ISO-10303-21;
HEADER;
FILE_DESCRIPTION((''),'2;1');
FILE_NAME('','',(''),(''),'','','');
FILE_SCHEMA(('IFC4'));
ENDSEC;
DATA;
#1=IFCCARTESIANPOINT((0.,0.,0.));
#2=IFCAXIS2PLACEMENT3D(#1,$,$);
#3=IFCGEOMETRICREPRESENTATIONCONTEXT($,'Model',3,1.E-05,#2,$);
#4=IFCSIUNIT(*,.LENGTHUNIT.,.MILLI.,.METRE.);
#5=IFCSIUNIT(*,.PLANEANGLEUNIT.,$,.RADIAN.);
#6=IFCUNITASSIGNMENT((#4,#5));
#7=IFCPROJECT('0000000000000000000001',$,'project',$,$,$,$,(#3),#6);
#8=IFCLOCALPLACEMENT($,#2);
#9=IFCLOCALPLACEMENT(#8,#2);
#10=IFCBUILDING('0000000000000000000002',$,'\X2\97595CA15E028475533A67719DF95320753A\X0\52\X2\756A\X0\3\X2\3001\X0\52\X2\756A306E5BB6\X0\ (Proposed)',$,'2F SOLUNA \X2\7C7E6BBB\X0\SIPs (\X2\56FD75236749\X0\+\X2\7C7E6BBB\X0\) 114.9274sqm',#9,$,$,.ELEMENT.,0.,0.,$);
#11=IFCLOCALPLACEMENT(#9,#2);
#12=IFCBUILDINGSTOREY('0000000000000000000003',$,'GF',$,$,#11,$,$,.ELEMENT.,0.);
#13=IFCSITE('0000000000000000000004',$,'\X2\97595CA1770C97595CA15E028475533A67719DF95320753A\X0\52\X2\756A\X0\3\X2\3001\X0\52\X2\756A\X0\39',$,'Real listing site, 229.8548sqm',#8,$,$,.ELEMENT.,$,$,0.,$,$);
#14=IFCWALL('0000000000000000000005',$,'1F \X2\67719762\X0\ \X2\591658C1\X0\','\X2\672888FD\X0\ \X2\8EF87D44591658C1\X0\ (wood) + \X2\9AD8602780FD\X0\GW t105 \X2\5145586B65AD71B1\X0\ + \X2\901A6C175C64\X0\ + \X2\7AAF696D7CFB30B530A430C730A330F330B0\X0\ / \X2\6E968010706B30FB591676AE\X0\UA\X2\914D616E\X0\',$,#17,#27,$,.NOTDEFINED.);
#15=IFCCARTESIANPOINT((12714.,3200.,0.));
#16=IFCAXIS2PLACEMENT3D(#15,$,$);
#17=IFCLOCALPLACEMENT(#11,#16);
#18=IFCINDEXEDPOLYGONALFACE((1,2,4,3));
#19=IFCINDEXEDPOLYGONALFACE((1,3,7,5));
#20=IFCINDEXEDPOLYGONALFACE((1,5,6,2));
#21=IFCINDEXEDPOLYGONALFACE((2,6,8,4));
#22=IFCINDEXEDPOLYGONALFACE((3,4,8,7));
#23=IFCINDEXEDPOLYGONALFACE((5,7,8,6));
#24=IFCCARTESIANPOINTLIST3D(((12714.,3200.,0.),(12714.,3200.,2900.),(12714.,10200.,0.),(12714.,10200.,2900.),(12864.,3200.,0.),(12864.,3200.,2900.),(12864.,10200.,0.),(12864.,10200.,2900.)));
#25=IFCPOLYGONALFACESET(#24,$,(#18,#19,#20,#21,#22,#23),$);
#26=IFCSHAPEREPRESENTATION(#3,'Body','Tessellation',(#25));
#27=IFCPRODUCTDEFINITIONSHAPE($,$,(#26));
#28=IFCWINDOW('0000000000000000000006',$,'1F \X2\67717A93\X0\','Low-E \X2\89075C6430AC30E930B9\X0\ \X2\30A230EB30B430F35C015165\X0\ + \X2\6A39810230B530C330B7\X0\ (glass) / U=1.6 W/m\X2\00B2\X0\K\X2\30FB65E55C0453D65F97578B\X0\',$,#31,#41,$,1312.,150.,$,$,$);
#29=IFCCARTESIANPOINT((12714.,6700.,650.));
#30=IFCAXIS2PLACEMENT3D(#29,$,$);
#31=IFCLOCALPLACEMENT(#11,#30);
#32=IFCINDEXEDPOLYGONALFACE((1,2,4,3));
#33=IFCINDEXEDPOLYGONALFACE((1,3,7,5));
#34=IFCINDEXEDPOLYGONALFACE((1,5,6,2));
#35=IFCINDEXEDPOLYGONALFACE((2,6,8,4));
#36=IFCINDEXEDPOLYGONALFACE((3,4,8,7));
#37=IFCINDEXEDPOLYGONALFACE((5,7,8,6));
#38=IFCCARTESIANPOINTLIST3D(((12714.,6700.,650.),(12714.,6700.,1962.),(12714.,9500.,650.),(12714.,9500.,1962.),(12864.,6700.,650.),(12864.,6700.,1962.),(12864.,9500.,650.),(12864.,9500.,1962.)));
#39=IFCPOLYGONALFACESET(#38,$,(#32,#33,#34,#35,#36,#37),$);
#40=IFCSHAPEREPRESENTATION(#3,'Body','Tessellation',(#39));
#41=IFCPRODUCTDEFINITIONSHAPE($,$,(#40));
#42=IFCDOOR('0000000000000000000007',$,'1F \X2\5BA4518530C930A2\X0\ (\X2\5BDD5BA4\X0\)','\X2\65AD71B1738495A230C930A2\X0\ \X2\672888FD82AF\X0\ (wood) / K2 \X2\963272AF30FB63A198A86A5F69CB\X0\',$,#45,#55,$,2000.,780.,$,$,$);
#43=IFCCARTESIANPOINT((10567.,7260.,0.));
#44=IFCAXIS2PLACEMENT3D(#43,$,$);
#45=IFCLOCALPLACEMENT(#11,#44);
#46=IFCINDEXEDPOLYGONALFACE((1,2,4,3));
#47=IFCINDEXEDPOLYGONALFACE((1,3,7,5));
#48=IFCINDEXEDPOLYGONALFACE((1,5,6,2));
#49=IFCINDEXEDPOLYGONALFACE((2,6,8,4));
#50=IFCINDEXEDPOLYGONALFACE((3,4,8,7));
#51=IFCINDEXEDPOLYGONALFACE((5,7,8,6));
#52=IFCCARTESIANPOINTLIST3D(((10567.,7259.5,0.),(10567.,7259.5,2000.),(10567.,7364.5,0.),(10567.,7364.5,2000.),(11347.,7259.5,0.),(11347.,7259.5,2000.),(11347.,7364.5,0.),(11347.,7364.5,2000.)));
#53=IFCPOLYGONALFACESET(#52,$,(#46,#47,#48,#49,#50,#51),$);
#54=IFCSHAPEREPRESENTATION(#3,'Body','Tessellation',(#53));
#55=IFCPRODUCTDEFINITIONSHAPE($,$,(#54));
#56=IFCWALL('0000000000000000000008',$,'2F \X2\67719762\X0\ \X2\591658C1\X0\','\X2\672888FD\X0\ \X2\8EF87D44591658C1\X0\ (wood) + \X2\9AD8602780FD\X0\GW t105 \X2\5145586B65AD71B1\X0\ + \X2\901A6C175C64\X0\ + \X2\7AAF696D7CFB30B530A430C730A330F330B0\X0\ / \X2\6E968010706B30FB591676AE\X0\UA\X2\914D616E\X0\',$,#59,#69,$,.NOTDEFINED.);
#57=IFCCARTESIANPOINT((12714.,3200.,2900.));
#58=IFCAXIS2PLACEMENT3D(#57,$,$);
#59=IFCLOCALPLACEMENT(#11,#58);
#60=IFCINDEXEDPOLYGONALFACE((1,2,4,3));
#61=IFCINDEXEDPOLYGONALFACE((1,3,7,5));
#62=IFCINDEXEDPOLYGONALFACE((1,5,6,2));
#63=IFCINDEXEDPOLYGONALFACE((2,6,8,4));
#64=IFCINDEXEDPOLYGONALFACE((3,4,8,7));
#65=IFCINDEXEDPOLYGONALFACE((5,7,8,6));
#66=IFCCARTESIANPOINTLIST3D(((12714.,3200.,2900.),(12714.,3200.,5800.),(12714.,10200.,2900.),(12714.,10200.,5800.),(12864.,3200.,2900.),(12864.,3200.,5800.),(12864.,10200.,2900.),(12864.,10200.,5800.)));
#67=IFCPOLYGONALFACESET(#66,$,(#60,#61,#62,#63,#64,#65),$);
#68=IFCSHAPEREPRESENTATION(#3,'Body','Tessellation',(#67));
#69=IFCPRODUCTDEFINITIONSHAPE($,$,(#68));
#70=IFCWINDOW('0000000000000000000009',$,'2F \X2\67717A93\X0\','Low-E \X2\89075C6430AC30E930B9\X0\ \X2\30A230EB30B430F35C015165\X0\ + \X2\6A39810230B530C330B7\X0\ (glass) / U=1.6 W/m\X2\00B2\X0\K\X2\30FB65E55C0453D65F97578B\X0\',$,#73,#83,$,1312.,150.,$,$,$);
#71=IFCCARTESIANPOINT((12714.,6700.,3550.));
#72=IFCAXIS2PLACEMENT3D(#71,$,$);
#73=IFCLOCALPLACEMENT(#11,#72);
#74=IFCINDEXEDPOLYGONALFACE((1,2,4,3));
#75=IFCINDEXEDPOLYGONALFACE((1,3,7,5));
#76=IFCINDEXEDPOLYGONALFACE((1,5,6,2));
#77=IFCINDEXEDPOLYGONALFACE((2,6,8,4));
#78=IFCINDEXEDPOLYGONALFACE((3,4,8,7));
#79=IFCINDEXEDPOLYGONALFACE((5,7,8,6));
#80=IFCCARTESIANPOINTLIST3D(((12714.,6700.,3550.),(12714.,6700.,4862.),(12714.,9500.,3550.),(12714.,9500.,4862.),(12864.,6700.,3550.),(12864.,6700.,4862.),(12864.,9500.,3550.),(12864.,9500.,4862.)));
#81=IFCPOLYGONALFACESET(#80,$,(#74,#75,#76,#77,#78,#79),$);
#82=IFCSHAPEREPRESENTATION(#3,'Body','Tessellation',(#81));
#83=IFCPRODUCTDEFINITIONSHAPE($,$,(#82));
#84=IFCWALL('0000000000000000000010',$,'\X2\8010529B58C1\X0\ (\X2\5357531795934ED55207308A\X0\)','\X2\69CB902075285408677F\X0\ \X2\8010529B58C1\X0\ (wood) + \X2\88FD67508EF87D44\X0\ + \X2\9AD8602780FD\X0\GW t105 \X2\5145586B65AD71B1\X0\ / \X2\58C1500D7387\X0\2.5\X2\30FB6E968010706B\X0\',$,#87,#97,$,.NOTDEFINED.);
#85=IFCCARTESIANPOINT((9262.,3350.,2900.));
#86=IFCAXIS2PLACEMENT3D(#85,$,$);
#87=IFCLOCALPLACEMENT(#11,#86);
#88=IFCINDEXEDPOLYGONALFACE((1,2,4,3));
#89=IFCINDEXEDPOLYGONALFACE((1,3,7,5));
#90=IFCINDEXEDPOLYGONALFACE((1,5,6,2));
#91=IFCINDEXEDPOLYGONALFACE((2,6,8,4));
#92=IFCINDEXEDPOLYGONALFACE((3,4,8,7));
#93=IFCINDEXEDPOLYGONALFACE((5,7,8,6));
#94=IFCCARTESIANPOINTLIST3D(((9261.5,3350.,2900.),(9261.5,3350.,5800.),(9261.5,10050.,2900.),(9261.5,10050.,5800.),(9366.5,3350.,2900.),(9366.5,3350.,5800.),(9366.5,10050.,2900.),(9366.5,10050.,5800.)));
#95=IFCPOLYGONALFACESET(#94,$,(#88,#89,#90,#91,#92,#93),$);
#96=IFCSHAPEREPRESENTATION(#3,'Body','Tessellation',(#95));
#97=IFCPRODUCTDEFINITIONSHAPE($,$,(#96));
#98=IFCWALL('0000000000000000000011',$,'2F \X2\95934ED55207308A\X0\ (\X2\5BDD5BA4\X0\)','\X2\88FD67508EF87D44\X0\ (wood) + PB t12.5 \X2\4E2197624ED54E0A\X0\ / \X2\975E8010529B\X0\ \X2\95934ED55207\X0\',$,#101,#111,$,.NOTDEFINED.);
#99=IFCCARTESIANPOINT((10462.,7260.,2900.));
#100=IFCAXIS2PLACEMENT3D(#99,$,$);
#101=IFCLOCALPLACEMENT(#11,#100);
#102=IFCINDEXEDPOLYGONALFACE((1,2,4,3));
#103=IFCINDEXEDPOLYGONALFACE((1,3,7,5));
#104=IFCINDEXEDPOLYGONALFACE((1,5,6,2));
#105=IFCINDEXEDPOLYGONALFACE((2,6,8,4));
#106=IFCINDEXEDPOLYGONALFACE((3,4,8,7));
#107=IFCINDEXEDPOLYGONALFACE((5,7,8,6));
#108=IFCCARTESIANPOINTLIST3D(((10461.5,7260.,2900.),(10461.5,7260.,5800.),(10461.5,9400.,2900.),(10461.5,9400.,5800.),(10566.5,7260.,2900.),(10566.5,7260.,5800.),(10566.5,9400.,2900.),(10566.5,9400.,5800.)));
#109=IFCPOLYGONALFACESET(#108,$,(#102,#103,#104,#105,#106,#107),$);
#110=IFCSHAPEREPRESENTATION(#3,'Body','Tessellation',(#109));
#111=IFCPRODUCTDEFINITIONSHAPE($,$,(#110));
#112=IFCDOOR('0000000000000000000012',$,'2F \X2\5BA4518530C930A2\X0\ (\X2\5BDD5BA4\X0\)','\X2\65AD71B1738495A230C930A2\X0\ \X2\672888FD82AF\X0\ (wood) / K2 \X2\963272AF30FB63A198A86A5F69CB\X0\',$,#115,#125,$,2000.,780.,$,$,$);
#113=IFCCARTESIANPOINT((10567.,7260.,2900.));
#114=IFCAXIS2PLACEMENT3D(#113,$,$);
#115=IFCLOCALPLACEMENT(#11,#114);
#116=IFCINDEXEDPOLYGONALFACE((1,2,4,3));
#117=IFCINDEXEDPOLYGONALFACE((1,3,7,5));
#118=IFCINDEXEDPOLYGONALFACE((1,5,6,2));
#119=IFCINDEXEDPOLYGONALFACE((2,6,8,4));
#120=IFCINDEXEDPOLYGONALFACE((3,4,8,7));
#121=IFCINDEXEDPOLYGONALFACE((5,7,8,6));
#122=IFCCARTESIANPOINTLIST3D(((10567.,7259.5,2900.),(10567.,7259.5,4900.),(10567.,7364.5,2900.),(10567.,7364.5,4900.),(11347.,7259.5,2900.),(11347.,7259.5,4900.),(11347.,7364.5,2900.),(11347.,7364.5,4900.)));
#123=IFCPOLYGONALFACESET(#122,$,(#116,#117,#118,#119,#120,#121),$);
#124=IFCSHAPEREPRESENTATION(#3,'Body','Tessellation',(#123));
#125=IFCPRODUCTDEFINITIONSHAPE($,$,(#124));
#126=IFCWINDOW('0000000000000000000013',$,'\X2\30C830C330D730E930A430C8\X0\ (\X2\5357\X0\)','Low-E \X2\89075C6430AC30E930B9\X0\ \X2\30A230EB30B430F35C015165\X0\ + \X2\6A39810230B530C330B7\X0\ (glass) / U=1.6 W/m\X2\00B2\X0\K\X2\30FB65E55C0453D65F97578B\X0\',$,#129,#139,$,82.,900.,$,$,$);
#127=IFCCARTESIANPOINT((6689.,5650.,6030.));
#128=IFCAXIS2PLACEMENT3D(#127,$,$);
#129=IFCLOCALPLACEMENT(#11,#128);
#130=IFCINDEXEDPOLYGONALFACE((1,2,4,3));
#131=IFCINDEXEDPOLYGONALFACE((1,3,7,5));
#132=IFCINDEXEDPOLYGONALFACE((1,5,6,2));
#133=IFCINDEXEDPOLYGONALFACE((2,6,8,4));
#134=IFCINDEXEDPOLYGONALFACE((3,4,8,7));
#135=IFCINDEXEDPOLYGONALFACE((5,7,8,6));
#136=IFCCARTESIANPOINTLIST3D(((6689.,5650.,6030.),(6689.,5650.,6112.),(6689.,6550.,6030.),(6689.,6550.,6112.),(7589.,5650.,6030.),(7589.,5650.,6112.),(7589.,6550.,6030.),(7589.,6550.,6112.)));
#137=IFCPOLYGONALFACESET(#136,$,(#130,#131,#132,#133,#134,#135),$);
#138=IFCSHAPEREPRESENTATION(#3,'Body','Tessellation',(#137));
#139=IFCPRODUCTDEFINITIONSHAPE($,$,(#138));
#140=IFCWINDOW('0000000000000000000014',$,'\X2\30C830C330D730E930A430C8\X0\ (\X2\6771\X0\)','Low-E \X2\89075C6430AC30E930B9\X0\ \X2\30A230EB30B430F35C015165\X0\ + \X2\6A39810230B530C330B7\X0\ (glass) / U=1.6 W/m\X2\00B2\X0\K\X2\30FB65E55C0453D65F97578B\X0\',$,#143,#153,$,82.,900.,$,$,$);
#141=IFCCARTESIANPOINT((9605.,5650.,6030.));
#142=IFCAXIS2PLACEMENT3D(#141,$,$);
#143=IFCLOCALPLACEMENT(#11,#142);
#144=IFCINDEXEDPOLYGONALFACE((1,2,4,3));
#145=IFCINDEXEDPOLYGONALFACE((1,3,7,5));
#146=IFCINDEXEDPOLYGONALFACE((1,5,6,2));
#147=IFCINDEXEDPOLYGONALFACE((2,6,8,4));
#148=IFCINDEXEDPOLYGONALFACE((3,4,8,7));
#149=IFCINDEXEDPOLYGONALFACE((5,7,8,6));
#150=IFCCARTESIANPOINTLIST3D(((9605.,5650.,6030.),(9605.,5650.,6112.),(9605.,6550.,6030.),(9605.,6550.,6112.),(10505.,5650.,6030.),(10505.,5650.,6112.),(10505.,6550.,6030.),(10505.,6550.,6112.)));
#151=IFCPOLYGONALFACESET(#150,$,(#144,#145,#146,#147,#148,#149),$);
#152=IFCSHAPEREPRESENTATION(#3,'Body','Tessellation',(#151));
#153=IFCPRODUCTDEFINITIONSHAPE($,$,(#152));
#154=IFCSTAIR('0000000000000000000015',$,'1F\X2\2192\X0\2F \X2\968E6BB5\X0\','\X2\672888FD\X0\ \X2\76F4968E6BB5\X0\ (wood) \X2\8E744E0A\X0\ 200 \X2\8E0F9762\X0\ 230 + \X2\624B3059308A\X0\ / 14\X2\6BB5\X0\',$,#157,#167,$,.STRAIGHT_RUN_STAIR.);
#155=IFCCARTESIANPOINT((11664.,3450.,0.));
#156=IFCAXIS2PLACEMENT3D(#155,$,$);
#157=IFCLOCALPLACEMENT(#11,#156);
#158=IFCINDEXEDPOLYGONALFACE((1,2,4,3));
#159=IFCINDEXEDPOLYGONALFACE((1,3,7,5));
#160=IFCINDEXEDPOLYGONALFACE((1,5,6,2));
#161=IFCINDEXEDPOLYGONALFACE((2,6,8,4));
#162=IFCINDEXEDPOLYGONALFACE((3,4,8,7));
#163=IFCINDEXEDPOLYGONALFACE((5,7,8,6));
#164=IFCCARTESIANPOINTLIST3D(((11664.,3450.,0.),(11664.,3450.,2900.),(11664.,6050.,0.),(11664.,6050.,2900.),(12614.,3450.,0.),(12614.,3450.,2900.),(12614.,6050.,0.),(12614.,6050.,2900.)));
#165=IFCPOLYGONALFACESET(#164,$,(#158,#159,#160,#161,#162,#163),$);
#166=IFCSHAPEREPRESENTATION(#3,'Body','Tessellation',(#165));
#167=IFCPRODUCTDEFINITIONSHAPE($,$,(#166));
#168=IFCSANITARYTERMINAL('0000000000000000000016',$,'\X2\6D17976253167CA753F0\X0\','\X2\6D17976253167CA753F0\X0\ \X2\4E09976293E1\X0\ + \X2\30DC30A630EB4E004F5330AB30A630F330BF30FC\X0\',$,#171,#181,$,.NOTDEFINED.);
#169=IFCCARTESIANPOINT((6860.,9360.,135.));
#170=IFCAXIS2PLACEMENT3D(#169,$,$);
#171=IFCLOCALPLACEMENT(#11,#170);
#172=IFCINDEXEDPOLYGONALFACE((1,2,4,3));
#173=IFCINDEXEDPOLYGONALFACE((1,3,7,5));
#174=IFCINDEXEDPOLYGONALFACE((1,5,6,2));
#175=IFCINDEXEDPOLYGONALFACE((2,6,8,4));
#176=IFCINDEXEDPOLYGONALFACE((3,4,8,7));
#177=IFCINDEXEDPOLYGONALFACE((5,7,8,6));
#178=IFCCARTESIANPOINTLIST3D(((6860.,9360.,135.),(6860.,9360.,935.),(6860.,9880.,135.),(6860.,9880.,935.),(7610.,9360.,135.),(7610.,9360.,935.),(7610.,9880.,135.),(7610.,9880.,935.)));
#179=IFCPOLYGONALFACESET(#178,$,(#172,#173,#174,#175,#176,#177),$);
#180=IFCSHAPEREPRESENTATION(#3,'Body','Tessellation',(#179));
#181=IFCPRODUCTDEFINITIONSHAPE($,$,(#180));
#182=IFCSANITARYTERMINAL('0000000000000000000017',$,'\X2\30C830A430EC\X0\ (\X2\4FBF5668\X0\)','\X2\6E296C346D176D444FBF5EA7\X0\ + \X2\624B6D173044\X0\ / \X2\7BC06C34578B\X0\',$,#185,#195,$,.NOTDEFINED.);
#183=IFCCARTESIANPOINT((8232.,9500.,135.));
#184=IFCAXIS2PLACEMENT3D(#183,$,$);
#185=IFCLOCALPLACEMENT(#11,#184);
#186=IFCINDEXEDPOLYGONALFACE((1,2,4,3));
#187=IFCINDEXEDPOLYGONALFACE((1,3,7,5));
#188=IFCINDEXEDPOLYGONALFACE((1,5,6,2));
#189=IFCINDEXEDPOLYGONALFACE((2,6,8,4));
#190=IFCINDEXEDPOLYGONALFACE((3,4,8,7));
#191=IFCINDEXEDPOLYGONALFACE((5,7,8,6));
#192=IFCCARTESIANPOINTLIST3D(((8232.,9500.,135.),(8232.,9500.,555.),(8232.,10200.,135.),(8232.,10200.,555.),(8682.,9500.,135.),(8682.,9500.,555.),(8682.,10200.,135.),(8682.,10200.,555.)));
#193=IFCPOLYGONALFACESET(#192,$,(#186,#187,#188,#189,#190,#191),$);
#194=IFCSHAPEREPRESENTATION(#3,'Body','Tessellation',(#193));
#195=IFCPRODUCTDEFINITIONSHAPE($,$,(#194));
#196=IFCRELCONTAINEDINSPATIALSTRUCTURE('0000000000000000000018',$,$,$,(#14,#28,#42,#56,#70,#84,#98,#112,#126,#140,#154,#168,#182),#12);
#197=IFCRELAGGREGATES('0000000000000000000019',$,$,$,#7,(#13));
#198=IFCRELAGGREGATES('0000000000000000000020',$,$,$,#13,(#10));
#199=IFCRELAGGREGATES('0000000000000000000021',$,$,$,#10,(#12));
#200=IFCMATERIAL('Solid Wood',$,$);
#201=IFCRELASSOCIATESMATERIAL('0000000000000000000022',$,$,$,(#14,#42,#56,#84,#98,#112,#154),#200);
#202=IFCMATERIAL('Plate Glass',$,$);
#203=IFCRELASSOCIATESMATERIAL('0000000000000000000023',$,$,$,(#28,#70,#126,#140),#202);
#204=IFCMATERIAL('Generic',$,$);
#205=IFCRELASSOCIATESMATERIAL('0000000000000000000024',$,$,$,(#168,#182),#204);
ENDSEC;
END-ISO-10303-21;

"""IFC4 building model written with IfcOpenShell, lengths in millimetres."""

from ifc_helpers import new_model, si_unit, frame, frame_2d, origin, place, context, project, spatial, rectangle, extrude, material, element, fill, save


model = new_model("IFC4")

# Units and contexts
model_context = context("Model", 3, precision=1e-05, world=origin())
ifc_project = project(units=[si_unit("LENGTHUNIT", "METRE", prefix="MILLI"), si_unit("PLANEANGLEUNIT", "RADIAN")], contexts=[model_context])

# Site, building, storey
site_placement = place(None, origin())
site = spatial("IfcSite", under=ifc_project, at=site_placement, Name="静岡県静岡市葵区東鷹匠町52番3、52番39", ObjectType="Real listing site, 229.8548sqm", CompositionType="ELEMENT", RefElevation=0.0)
building_placement = place(site_placement, origin())
building = spatial("IfcBuilding", under=site, at=building_placement, Name="静岡市葵区東鷹匠町52番3、52番の家 (Proposed)", ObjectType="2F SOLUNA 籾殻SIPs (国産杉+籾殻) 114.9274sqm", CompositionType="ELEMENT", ElevationOfRefHeight=0.0, ElevationOfTerrain=0.0)
storey_placement = place(building_placement, origin())
storey = spatial("IfcBuildingStorey", under=building, at=storey_placement, Name="GF", CompositionType="ELEMENT", Elevation=0.0)

# Wall, opening, window
ifc_material_1 = material(Name="Solid Wood")
wall_1_placement = place(storey_placement, frame((12714.0, 3200.0, 0.0)))
wall_1 = element("IfcWall", 1, at=wall_1_placement, inside=storey, material=ifc_material_1, Name="1F 東面 外壁", Description="木製 軸組外壁 (wood) + 高性能GW t105 充填断熱 + 通気層 + 窯業系サイディング / 準耐火・外皮UA配慮", PredefinedType="NOTDEFINED", context=model_context, shape_type="SweptSolid", body=[
    extrude(rectangle(XDim=150.0, YDim=7000.0, at=frame_2d((75.0, 3500.0))), frame((12714.0, 3200.0, 0.0)), (0.0, 0.0, 1.0), 2900.0),
])
opening_1_placement = place(storey_placement, frame((12714.0, 6700.0, 650.0)))
opening_1 = element("IfcOpeningElement", 2, at=opening_1_placement, cuts=wall_1, PredefinedType="NOTDEFINED", context=model_context, shape_type="SweptSolid", body=[
    extrude(rectangle(XDim=150.0, YDim=2800.0, at=frame_2d((75.0, 1400.0))), frame((12714.0, 6700.0, 650.0)), (0.0, 0.0, 1.0), 1312.0),
])
ifc_material_2 = material(Name="Plate Glass")
window_1_placement = place(storey_placement, frame((12714.0, 6700.0, 650.0)))
window_1 = element("IfcWindow", 3, at=window_1_placement, inside=storey, material=ifc_material_2, Name="1F 東窓", Description="Low-E 複層ガラス アルゴン封入 + 樹脂サッシ (glass) / U=1.6 W/m²K・日射取得型", OverallHeight=1312.0, OverallWidth=150.0, context=model_context, shape_type="SweptSolid", body=[
    extrude(rectangle(XDim=150.0, YDim=2800.0, at=frame_2d((75.0, 1400.0))), frame((12714.0, 6700.0, 650.0)), (0.0, 0.0, 1.0), 1312.0),
])
fill(opening_1, window_1)

# Door
door_1_placement = place(storey_placement, frame((10567.0, 7260.0, 0.0)))
element("IfcDoor", 4, at=door_1_placement, inside=storey, material=ifc_material_1, Name="1F 室内ドア (寝室)", Description="断熱玄関ドア 木製芯 (wood) / K2 防犯・採風機構", OverallHeight=2000.0, OverallWidth=780.0, context=model_context, shape_type="SweptSolid", body=[
    extrude(rectangle(XDim=780.0, YDim=105.0, at=frame_2d((390.0, 52.0))), frame((10567.0, 7260.0, 0.0)), (0.0, 0.0, 1.0), 2000.0),
])

# Wall, opening, window
wall_2_placement = place(storey_placement, frame((12714.0, 3200.0, 2900.0)))
wall_2 = element("IfcWall", 5, at=wall_2_placement, inside=storey, material=ifc_material_1, Name="2F 東面 外壁", Description="木製 軸組外壁 (wood) + 高性能GW t105 充填断熱 + 通気層 + 窯業系サイディング / 準耐火・外皮UA配慮", PredefinedType="NOTDEFINED", context=model_context, shape_type="SweptSolid", body=[
    extrude(rectangle(XDim=150.0, YDim=7000.0, at=frame_2d((75.0, 3500.0))), frame((12714.0, 3200.0, 2900.0)), (0.0, 0.0, 1.0), 2900.0),
])
opening_2_placement = place(storey_placement, frame((12714.0, 6700.0, 3550.0)))
opening_2 = element("IfcOpeningElement", 6, at=opening_2_placement, cuts=wall_2, PredefinedType="NOTDEFINED", context=model_context, shape_type="SweptSolid", body=[
    extrude(rectangle(XDim=150.0, YDim=2800.0, at=frame_2d((75.0, 1400.0))), frame((12714.0, 6700.0, 3550.0)), (0.0, 0.0, 1.0), 1312.0),
])
window_2_placement = place(storey_placement, frame((12714.0, 6700.0, 3550.0)))
window_2 = element("IfcWindow", 7, at=window_2_placement, inside=storey, material=ifc_material_2, Name="2F 東窓", Description="Low-E 複層ガラス アルゴン封入 + 樹脂サッシ (glass) / U=1.6 W/m²K・日射取得型", OverallHeight=1312.0, OverallWidth=150.0, context=model_context, shape_type="SweptSolid", body=[
    extrude(rectangle(XDim=150.0, YDim=2800.0, at=frame_2d((75.0, 1400.0))), frame((12714.0, 6700.0, 3550.0)), (0.0, 0.0, 1.0), 1312.0),
])
fill(opening_2, window_2)

# Walls
wall_3_placement = place(storey_placement, frame((9262.0, 3350.0, 2900.0)))
element("IfcWall", 8, at=wall_3_placement, inside=storey, material=ifc_material_1, Name="耐力壁 (南北間仕切り)", Description="構造用合板 耐力壁 (wood) + 製材軸組 + 高性能GW t105 充填断熱 / 壁倍率2.5・準耐火", PredefinedType="NOTDEFINED", context=model_context, shape_type="SweptSolid", body=[
    extrude(rectangle(XDim=105.0, YDim=6700.0, at=frame_2d((52.0, 3350.0))), frame((9262.0, 3350.0, 2900.0)), (0.0, 0.0, 1.0), 2900.0),
])
wall_4_placement = place(storey_placement, frame((10462.0, 7260.0, 2900.0)))
element("IfcWall", 9, at=wall_4_placement, inside=storey, material=ifc_material_1, Name="2F 間仕切り (寝室)", Description="製材軸組 (wood) + PB t12.5 両面仕上 / 非耐力 間仕切", PredefinedType="NOTDEFINED", context=model_context, shape_type="SweptSolid", body=[
    extrude(rectangle(XDim=105.0, YDim=2140.0, at=frame_2d((52.0, 1070.0))), frame((10462.0, 7260.0, 2900.0)), (0.0, 0.0, 1.0), 2900.0),
])

# Door
door_2_placement = place(storey_placement, frame((10567.0, 7260.0, 2900.0)))
element("IfcDoor", 10, at=door_2_placement, inside=storey, material=ifc_material_1, Name="2F 室内ドア (寝室)", Description="断熱玄関ドア 木製芯 (wood) / K2 防犯・採風機構", OverallHeight=2000.0, OverallWidth=780.0, context=model_context, shape_type="SweptSolid", body=[
    extrude(rectangle(XDim=780.0, YDim=105.0, at=frame_2d((390.0, 52.0))), frame((10567.0, 7260.0, 2900.0)), (0.0, 0.0, 1.0), 2000.0),
])

# Windows
window_3_placement = place(storey_placement, frame((6689.0, 5650.0, 6030.0)))
element("IfcWindow", 11, at=window_3_placement, inside=storey, material=ifc_material_2, Name="トップライト (南)", Description="Low-E 複層ガラス アルゴン封入 + 樹脂サッシ (glass) / U=1.6 W/m²K・日射取得型", OverallHeight=82.0, OverallWidth=900.0, context=model_context, shape_type="SweptSolid", body=[
    extrude(rectangle(XDim=900.0, YDim=900.0, at=frame_2d((450.0, 450.0))), frame((6689.0, 5650.0, 6030.0)), (0.0, 0.0, 1.0), 82.0),
])
window_4_placement = place(storey_placement, frame((9605.0, 5650.0, 6030.0)))
element("IfcWindow", 12, at=window_4_placement, inside=storey, material=ifc_material_2, Name="トップライト (東)", Description="Low-E 複層ガラス アルゴン封入 + 樹脂サッシ (glass) / U=1.6 W/m²K・日射取得型", OverallHeight=82.0, OverallWidth=900.0, context=model_context, shape_type="SweptSolid", body=[
    extrude(rectangle(XDim=900.0, YDim=900.0, at=frame_2d((450.0, 450.0))), frame((9605.0, 5650.0, 6030.0)), (0.0, 0.0, 1.0), 82.0),
])

# Stair
stair_placement = place(storey_placement, frame((11664.0, 3450.0, 0.0)))
element("IfcStair", 13, at=stair_placement, inside=storey, material=ifc_material_1, Name="1F→2F 階段", Description="木製 直階段 (wood) 蹴上 200 踏面 230 + 手すり / 14段", PredefinedType="STRAIGHT_RUN_STAIR", context=model_context, shape_type="SweptSolid", body=[
    extrude(rectangle(XDim=950.0, YDim=2600.0, at=frame_2d((475.0, 1300.0))), frame((11664.0, 3450.0, 0.0)), (0.0, 0.0, 1.0), 2900.0),
])

# Sanitary terminals
ifc_material_3 = material(Name="Generic")
sanitary_terminal_1_placement = place(storey_placement, frame((6860.0, 9360.0, 135.0)))
element("IfcSanitaryTerminal", 14, at=sanitary_terminal_1_placement, inside=storey, material=ifc_material_3, Name="洗面化粧台", Description="洗面化粧台 三面鏡 + ボウル一体カウンター", PredefinedType="NOTDEFINED", context=model_context, shape_type="SweptSolid", body=[
    extrude(rectangle(XDim=750.0, YDim=520.0, at=frame_2d((375.0, 260.0))), frame((6860.0, 9360.0, 135.0)), (0.0, 0.0, 1.0), 800.0),
])
sanitary_terminal_2_placement = place(storey_placement, frame((8232.0, 9500.0, 135.0)))
element("IfcSanitaryTerminal", 15, at=sanitary_terminal_2_placement, inside=storey, material=ifc_material_3, Name="トイレ (便器)", Description="温水洗浄便座 + 手洗い / 節水型", PredefinedType="NOTDEFINED", context=model_context, shape_type="SweptSolid", body=[
    extrude(rectangle(XDim=450.0, YDim=700.0, at=frame_2d((225.0, 350.0))), frame((8232.0, 9500.0, 135.0)), (0.0, 0.0, 1.0), 420.0),
])

save(model, "model.ifc")
